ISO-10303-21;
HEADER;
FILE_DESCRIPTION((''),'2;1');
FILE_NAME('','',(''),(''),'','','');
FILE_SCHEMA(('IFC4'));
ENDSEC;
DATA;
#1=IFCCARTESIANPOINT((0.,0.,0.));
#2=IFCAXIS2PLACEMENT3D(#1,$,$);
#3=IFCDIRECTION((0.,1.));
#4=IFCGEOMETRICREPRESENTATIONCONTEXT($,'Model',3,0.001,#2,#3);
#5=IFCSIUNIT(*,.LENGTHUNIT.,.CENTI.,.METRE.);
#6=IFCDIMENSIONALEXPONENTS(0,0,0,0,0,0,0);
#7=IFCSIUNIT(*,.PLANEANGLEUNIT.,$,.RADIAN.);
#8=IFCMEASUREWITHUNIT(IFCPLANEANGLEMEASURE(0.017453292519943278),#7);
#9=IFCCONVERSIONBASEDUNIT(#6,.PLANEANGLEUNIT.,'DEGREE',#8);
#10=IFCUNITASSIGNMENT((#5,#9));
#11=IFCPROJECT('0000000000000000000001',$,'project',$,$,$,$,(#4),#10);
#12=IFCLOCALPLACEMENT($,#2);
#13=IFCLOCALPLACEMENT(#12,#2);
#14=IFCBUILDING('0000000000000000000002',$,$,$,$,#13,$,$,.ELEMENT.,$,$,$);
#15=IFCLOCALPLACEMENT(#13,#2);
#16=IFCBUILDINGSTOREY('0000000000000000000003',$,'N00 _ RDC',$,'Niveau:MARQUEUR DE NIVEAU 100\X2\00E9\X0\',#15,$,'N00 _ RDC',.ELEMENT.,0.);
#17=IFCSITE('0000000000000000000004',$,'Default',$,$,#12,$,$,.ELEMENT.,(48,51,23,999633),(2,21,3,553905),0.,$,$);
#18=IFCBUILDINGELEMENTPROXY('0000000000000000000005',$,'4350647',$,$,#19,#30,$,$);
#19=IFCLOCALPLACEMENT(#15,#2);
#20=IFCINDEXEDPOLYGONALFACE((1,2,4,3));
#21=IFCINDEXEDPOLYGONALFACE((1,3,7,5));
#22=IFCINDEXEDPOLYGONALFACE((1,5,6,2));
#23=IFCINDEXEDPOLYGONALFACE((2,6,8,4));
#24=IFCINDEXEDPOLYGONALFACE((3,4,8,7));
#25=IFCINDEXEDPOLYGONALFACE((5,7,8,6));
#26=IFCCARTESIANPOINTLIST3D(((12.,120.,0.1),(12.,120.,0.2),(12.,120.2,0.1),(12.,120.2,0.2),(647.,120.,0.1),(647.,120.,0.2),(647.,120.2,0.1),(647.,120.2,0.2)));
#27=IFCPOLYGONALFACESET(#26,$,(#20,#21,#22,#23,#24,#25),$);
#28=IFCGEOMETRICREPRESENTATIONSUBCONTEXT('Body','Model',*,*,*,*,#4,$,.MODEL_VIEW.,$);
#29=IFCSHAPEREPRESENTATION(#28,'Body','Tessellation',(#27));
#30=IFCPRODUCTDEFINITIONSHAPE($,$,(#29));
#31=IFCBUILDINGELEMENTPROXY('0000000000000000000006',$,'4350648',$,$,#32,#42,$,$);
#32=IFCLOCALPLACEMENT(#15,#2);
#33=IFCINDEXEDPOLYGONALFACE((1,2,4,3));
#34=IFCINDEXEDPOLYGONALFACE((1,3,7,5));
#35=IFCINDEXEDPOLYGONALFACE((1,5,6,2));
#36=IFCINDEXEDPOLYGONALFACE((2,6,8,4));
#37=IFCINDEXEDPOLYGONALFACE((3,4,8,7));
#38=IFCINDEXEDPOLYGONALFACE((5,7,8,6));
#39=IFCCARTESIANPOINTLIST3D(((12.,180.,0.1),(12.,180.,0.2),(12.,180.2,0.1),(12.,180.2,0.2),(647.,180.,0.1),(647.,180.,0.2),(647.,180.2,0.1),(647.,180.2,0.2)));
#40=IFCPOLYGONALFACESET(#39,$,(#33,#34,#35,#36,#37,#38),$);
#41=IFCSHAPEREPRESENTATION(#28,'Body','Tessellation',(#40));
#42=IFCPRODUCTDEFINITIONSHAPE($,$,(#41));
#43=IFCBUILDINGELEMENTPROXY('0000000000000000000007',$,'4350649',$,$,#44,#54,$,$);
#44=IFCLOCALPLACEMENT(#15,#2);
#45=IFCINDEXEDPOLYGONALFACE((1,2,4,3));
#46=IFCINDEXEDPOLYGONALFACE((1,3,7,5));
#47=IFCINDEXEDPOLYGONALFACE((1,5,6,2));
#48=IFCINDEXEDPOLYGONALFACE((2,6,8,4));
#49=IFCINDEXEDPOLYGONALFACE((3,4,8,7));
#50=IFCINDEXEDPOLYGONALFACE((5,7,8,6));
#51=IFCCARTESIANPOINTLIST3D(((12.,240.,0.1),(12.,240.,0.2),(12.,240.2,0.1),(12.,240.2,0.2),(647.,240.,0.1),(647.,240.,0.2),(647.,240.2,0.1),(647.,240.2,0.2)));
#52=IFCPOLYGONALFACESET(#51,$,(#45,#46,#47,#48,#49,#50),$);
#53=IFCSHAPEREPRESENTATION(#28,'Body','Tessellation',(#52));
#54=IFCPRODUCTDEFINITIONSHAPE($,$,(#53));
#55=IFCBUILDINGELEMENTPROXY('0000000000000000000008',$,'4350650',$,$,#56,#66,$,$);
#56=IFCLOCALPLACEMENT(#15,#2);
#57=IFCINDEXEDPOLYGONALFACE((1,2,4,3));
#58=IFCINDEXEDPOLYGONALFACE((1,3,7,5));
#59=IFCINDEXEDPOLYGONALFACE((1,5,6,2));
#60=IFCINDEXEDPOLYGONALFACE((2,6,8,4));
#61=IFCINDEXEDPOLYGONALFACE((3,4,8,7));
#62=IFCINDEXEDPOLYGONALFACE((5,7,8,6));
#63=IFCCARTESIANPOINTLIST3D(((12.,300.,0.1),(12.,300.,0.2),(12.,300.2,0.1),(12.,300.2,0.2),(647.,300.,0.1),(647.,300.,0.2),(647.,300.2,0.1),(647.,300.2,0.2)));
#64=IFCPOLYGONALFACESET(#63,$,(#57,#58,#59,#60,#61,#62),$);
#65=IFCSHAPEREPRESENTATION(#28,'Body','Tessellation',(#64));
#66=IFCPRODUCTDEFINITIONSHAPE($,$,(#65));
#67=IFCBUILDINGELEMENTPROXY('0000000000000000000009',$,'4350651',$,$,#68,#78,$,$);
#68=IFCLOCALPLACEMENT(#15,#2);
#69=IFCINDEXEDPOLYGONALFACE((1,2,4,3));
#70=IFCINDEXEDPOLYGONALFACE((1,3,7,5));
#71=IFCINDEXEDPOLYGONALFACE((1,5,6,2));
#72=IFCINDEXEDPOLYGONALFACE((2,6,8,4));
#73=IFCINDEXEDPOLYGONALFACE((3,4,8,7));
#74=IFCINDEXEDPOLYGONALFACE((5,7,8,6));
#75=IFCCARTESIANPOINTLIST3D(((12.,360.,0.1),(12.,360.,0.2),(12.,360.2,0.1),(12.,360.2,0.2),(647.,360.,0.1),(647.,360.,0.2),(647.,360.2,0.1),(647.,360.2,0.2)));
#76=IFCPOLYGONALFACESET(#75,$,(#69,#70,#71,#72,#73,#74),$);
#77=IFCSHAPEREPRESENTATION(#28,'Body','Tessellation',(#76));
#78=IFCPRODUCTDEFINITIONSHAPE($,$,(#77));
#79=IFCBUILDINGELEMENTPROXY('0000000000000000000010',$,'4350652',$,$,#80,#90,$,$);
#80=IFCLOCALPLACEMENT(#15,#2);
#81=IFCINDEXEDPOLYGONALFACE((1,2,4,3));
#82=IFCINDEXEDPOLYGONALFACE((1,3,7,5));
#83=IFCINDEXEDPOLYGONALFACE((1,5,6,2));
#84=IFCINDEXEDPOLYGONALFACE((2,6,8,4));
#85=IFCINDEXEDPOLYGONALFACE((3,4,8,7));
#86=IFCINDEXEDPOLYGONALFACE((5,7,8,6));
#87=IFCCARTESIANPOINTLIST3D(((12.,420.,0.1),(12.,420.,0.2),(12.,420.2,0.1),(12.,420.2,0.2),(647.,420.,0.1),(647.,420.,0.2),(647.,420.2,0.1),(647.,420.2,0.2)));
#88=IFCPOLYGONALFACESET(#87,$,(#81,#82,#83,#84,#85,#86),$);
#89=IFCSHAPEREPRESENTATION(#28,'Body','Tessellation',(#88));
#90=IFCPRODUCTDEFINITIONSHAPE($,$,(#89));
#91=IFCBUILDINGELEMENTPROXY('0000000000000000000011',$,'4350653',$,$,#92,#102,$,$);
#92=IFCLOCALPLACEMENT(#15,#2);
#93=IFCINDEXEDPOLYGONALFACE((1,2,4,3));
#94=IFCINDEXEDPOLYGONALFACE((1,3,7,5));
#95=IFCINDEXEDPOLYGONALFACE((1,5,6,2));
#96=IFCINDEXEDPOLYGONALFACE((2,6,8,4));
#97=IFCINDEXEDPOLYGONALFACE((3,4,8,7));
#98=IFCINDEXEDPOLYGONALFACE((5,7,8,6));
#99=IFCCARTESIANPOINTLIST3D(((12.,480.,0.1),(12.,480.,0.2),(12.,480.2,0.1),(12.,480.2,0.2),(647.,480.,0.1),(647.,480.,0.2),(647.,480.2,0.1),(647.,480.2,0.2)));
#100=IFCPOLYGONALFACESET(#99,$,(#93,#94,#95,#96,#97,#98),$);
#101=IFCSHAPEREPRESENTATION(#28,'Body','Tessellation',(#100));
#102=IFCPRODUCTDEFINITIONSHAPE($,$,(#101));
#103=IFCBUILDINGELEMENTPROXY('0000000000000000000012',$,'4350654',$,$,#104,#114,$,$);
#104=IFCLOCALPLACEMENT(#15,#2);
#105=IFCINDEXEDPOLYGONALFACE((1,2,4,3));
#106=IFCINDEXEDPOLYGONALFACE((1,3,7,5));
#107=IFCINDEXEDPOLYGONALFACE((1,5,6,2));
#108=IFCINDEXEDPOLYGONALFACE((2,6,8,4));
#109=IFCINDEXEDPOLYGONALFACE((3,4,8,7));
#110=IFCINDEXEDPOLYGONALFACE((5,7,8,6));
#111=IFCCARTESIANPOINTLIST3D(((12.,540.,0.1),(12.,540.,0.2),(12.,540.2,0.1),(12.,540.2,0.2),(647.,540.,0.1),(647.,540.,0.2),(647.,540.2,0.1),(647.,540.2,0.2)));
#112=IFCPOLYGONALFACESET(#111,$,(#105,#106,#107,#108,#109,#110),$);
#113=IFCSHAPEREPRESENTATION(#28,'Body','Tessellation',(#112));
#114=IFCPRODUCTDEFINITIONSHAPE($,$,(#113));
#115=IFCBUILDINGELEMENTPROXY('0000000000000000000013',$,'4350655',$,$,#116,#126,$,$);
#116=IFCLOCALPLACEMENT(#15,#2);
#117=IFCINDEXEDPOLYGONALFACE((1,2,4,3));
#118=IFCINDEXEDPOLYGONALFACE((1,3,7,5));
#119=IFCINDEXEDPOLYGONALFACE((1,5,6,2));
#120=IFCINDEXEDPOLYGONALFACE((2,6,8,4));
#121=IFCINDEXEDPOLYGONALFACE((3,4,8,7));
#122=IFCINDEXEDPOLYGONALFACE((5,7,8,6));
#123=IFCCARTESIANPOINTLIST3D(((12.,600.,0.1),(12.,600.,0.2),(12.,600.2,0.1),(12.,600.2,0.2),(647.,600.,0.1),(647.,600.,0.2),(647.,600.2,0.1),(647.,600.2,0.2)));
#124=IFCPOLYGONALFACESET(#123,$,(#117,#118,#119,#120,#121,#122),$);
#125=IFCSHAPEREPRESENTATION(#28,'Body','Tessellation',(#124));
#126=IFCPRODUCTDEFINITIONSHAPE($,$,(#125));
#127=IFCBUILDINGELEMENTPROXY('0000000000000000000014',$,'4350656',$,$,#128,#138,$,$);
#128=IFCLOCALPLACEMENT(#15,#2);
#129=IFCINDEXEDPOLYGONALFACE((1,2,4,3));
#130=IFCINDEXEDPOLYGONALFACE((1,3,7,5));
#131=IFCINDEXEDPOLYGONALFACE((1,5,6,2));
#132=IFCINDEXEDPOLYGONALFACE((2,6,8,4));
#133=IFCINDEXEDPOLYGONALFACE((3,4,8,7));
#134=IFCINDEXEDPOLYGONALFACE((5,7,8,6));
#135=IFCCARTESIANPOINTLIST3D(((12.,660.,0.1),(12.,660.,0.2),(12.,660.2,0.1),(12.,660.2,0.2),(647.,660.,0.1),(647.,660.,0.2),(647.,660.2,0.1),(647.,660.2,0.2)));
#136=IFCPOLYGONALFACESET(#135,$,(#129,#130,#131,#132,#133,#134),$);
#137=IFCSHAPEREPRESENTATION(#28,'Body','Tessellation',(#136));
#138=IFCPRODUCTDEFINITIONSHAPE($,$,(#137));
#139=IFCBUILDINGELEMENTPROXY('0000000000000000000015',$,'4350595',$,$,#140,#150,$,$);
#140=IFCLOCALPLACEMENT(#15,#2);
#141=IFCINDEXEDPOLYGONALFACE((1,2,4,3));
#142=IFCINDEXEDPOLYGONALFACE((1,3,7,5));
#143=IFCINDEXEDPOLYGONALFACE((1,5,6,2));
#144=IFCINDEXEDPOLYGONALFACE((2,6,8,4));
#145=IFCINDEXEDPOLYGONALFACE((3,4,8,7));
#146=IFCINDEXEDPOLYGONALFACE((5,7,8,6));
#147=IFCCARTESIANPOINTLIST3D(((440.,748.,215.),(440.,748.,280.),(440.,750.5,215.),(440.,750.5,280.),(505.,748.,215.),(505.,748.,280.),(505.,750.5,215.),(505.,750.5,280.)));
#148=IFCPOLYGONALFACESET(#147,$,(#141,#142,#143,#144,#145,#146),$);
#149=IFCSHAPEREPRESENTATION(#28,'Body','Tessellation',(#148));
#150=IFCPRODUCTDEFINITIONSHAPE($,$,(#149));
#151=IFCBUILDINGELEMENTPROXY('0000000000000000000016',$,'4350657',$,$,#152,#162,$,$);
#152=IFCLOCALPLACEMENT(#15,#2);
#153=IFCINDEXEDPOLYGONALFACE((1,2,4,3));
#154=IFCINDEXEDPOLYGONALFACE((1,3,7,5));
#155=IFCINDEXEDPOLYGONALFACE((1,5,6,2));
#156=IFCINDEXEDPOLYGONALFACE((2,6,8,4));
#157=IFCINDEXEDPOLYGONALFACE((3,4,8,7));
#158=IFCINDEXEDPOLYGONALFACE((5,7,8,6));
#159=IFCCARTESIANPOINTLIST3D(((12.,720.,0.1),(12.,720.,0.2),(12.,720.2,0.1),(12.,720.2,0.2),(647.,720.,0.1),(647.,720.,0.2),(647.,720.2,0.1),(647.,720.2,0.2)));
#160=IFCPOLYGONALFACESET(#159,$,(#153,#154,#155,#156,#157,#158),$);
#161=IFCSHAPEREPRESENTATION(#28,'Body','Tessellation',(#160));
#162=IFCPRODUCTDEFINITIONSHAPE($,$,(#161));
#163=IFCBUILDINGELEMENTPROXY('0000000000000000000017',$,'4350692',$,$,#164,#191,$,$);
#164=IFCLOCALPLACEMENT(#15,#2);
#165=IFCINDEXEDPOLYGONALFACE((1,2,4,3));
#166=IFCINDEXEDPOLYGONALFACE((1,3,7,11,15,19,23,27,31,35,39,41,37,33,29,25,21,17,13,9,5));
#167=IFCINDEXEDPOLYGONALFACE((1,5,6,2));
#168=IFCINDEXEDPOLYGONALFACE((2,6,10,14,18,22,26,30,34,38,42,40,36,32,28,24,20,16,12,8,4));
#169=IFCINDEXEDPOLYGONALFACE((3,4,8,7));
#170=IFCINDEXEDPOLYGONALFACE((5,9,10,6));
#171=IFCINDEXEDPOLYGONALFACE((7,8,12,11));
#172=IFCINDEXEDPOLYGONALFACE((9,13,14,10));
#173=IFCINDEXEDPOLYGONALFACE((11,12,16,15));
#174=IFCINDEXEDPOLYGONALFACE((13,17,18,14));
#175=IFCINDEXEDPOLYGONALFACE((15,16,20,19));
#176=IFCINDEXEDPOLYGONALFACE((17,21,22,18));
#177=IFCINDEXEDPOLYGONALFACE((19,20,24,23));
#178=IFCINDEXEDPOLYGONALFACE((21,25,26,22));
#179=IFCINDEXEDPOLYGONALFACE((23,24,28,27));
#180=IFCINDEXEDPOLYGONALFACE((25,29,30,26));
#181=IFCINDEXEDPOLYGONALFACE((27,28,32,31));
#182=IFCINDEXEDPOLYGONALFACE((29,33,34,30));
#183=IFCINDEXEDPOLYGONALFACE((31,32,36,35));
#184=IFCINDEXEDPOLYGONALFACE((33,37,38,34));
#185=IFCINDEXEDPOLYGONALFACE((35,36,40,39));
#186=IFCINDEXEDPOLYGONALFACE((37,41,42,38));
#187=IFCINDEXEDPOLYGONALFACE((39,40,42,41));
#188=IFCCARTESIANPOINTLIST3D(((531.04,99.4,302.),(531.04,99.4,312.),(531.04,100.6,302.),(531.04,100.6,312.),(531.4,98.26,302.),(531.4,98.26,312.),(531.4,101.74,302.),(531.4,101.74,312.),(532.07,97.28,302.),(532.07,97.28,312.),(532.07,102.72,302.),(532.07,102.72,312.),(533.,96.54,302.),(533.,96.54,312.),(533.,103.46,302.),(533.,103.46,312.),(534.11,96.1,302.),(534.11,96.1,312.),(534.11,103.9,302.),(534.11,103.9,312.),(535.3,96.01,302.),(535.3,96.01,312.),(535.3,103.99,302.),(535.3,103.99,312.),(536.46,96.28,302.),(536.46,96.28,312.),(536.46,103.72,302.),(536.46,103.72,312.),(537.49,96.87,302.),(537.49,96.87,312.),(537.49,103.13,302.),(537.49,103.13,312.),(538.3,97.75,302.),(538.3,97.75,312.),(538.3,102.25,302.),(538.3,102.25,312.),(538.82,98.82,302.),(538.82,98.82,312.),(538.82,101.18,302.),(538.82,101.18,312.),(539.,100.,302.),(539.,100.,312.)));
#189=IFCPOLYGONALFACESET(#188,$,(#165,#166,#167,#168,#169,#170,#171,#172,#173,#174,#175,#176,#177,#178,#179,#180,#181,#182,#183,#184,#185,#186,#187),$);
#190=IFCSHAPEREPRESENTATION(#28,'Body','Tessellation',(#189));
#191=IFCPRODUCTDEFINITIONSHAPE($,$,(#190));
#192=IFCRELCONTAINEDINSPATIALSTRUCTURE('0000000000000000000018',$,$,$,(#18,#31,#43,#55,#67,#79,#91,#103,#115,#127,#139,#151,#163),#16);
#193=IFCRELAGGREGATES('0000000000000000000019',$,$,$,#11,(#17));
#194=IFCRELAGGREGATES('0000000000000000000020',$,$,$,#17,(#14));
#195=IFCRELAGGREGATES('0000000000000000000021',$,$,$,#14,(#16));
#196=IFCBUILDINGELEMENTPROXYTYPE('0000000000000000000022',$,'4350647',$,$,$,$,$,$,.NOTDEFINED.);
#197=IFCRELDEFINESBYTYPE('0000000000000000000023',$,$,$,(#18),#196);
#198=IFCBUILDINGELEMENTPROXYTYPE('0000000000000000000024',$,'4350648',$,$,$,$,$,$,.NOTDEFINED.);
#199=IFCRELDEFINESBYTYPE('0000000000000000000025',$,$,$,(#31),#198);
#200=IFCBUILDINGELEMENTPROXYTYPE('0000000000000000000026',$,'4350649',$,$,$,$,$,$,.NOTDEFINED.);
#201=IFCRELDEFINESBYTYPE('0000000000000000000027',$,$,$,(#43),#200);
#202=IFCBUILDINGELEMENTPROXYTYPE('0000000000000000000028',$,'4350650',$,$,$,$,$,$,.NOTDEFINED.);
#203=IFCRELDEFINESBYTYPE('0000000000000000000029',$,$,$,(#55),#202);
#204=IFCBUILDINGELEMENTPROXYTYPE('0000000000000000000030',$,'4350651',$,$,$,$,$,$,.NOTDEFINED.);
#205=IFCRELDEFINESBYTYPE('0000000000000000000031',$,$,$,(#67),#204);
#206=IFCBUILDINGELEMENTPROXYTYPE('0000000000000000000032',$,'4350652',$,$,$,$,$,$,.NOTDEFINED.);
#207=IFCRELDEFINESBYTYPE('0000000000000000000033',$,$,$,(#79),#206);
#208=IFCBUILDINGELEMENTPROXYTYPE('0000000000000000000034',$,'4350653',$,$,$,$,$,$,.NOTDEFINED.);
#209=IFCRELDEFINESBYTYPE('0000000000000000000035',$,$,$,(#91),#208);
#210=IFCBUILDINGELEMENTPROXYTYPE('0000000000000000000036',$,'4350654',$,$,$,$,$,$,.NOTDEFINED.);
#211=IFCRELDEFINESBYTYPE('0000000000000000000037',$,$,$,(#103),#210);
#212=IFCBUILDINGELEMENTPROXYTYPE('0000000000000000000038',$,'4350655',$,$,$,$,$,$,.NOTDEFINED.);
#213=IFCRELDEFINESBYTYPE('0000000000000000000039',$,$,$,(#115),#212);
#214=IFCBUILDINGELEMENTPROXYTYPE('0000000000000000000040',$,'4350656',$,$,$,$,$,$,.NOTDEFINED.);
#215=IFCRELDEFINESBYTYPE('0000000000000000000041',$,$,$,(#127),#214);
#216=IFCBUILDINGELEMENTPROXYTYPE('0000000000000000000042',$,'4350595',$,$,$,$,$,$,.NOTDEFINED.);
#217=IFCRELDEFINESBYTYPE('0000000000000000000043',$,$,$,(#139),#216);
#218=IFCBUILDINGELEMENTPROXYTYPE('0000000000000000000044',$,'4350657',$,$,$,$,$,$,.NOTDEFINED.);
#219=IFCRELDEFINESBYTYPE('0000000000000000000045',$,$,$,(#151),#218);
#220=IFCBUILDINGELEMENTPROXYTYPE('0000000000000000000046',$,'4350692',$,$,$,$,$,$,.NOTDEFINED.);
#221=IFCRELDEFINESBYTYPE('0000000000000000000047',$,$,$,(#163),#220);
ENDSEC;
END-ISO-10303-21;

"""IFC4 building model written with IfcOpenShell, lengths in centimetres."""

from ifc_helpers import new_model, entity, si_unit, converted_unit, direction, frame, frame_2d, origin, origin_2d_with_axis, place, context, subcontext, project, spatial, rectangle, circle, extrude, type_object, element, save


model = new_model("IFC4")

# Units and contexts
model_context = context("Model", 3, precision=0.001, world=origin(), true_north=direction((0.0, 1.0)))
body_context = subcontext(model_context, "Body", "Model", "MODEL_VIEW")
ifc_project = project(units=[si_unit("LENGTHUNIT", "METRE", prefix="CENTI"), converted_unit("PLANEANGLEUNIT", "DEGREE", entity("IfcPlaneAngleMeasure", 0.017453292519943278), si_unit("PLANEANGLEUNIT", "RADIAN"), dimensions=[0, 0, 0, 0, 0, 0, 0])], contexts=[model_context])

# Site, building, storey
site_placement = place(None, origin())
site = spatial("IfcSite", under=ifc_project, at=site_placement, Name="Default", CompositionType="ELEMENT", RefLatitude=(48, 51, 23, 999633), RefLongitude=(2, 21, 3, 553905), RefElevation=0.0)
building_placement = place(site_placement, origin())
building = spatial("IfcBuilding", under=site, at=building_placement, CompositionType="ELEMENT")
storey_placement = place(building_placement, origin())
storey = spatial("IfcBuildingStorey", under=building, at=storey_placement, Name="N00 _ RDC", ObjectType="Niveau:MARQUEUR DE NIVEAU 100é", LongName="N00 _ RDC", CompositionType="ELEMENT", Elevation=0.0)

# Building element proxies
building_element_proxy_type_1 = type_object("IfcBuildingElementProxyType", Name="4350647", PredefinedType="NOTDEFINED")
proxy_1_placement = place(storey_placement, origin())
element("IfcBuildingElementProxy", 1, at=proxy_1_placement, inside=storey, type_object=building_element_proxy_type_1, Name="4350647", context=body_context, shape_type="SweptSolid", body=[
    extrude(rectangle(XDim=635.0, YDim=0.2, at=frame_2d((0.0, 0.0), x_axis=(1.0, 0.0))), frame((329.5, 120.1, 0.1)), (0.0, 0.0, 1.0), 0.1),
])
building_element_proxy_type_2 = type_object("IfcBuildingElementProxyType", Name="4350648", PredefinedType="NOTDEFINED")
proxy_2_placement = place(storey_placement, origin())
element("IfcBuildingElementProxy", 2, at=proxy_2_placement, inside=storey, type_object=building_element_proxy_type_2, Name="4350648", context=body_context, shape_type="SweptSolid", body=[
    extrude(rectangle(XDim=635.0, YDim=0.2, at=frame_2d((0.0, 0.0), x_axis=(1.0, 0.0))), frame((329.5, 180.1, 0.1)), (0.0, 0.0, 1.0), 0.1),
])
building_element_proxy_type_3 = type_object("IfcBuildingElementProxyType", Name="4350649", PredefinedType="NOTDEFINED")
proxy_3_placement = place(storey_placement, origin())
element("IfcBuildingElementProxy", 3, at=proxy_3_placement, inside=storey, type_object=building_element_proxy_type_3, Name="4350649", context=body_context, shape_type="SweptSolid", body=[
    extrude(rectangle(XDim=635.0, YDim=0.2, at=frame_2d((0.0, 0.0), x_axis=(1.0, 0.0))), frame((329.5, 240.1, 0.1)), (0.0, 0.0, 1.0), 0.1),
])
building_element_proxy_type_4 = type_object("IfcBuildingElementProxyType", Name="4350650", PredefinedType="NOTDEFINED")
proxy_4_placement = place(storey_placement, origin())
element("IfcBuildingElementProxy", 4, at=proxy_4_placement, inside=storey, type_object=building_element_proxy_type_4, Name="4350650", context=body_context, shape_type="SweptSolid", body=[
    extrude(rectangle(XDim=635.0, YDim=0.2, at=frame_2d((0.0, 0.0), x_axis=(1.0, 0.0))), frame((329.5, 300.1, 0.1)), (0.0, 0.0, 1.0), 0.1),
])
building_element_proxy_type_5 = type_object("IfcBuildingElementProxyType", Name="4350651", PredefinedType="NOTDEFINED")
proxy_5_placement = place(storey_placement, origin())
element("IfcBuildingElementProxy", 5, at=proxy_5_placement, inside=storey, type_object=building_element_proxy_type_5, Name="4350651", context=body_context, shape_type="SweptSolid", body=[
    extrude(rectangle(XDim=635.0, YDim=0.2, at=frame_2d((0.0, 0.0), x_axis=(1.0, 0.0))), frame((329.5, 360.1, 0.1)), (0.0, 0.0, 1.0), 0.1),
])
building_element_proxy_type_6 = type_object("IfcBuildingElementProxyType", Name="4350652", PredefinedType="NOTDEFINED")
proxy_6_placement = place(storey_placement, origin())
element("IfcBuildingElementProxy", 6, at=proxy_6_placement, inside=storey, type_object=building_element_proxy_type_6, Name="4350652", context=body_context, shape_type="SweptSolid", body=[
    extrude(rectangle(XDim=635.0, YDim=0.2, at=frame_2d((0.0, 0.0), x_axis=(1.0, 0.0))), frame((329.5, 420.1, 0.1)), (0.0, 0.0, 1.0), 0.1),
])
building_element_proxy_type_7 = type_object("IfcBuildingElementProxyType", Name="4350653", PredefinedType="NOTDEFINED")
proxy_7_placement = place(storey_placement, origin())
element("IfcBuildingElementProxy", 7, at=proxy_7_placement, inside=storey, type_object=building_element_proxy_type_7, Name="4350653", context=body_context, shape_type="SweptSolid", body=[
    extrude(rectangle(XDim=635.0, YDim=0.2, at=frame_2d((0.0, 0.0), x_axis=(1.0, 0.0))), frame((329.5, 480.1, 0.1)), (0.0, 0.0, 1.0), 0.1),
])
building_element_proxy_type_8 = type_object("IfcBuildingElementProxyType", Name="4350654", PredefinedType="NOTDEFINED")
proxy_8_placement = place(storey_placement, origin())
element("IfcBuildingElementProxy", 8, at=proxy_8_placement, inside=storey, type_object=building_element_proxy_type_8, Name="4350654", context=body_context, shape_type="SweptSolid", body=[
    extrude(rectangle(XDim=635.0, YDim=0.2, at=frame_2d((0.0, 0.0), x_axis=(1.0, 0.0))), frame((329.5, 540.1, 0.1)), (0.0, 0.0, 1.0), 0.1),
])
building_element_proxy_type_9 = type_object("IfcBuildingElementProxyType", Name="4350655", PredefinedType="NOTDEFINED")
proxy_9_placement = place(storey_placement, origin())
element("IfcBuildingElementProxy", 9, at=proxy_9_placement, inside=storey, type_object=building_element_proxy_type_9, Name="4350655", context=body_context, shape_type="SweptSolid", body=[
    extrude(rectangle(XDim=635.0, YDim=0.2, at=frame_2d((0.0, 0.0), x_axis=(1.0, 0.0))), frame((329.5, 600.1, 0.1)), (0.0, 0.0, 1.0), 0.1),
])
building_element_proxy_type_10 = type_object("IfcBuildingElementProxyType", Name="4350656", PredefinedType="NOTDEFINED")
proxy_10_placement = place(storey_placement, origin())
element("IfcBuildingElementProxy", 10, at=proxy_10_placement, inside=storey, type_object=building_element_proxy_type_10, Name="4350656", context=body_context, shape_type="SweptSolid", body=[
    extrude(rectangle(XDim=635.0, YDim=0.2, at=frame_2d((0.0, 0.0), x_axis=(1.0, 0.0))), frame((329.5, 660.1, 0.1)), (0.0, 0.0, 1.0), 0.1),
])
building_element_proxy_type_11 = type_object("IfcBuildingElementProxyType", Name="4350595", PredefinedType="NOTDEFINED")
proxy_11_placement = place(storey_placement, origin())
element("IfcBuildingElementProxy", 11, at=proxy_11_placement, inside=storey, type_object=building_element_proxy_type_11, Name="4350595", context=body_context, shape_type="SweptSolid", body=[
    extrude(rectangle(XDim=65.0, YDim=2.5, at=frame_2d((0.0, 0.0), x_axis=(1.0, 0.0))), frame((472.5, 749.25, 215.0)), (0.0, 0.0, 1.0), 65.0),
])
building_element_proxy_type_12 = type_object("IfcBuildingElementProxyType", Name="4350657", PredefinedType="NOTDEFINED")
proxy_12_placement = place(storey_placement, origin())
element("IfcBuildingElementProxy", 12, at=proxy_12_placement, inside=storey, type_object=building_element_proxy_type_12, Name="4350657", context=body_context, shape_type="SweptSolid", body=[
    extrude(rectangle(XDim=635.0, YDim=0.2, at=frame_2d((0.0, 0.0), x_axis=(1.0, 0.0))), frame((329.5, 720.1, 0.1)), (0.0, 0.0, 1.0), 0.1),
])
building_element_proxy_type_13 = type_object("IfcBuildingElementProxyType", Name="4350692", PredefinedType="NOTDEFINED")
proxy_13_placement = place(storey_placement, origin())
element("IfcBuildingElementProxy", 13, at=proxy_13_placement, inside=storey, type_object=building_element_proxy_type_13, Name="4350692", context=body_context, shape_type="SweptSolid", body=[
    extrude(circle(Radius=4.0, at=origin_2d_with_axis()), frame((535.0, 100.0, 302.0)), (0.0, 0.0, 1.0), 10.0),
])

save(model, "model.ifc")
